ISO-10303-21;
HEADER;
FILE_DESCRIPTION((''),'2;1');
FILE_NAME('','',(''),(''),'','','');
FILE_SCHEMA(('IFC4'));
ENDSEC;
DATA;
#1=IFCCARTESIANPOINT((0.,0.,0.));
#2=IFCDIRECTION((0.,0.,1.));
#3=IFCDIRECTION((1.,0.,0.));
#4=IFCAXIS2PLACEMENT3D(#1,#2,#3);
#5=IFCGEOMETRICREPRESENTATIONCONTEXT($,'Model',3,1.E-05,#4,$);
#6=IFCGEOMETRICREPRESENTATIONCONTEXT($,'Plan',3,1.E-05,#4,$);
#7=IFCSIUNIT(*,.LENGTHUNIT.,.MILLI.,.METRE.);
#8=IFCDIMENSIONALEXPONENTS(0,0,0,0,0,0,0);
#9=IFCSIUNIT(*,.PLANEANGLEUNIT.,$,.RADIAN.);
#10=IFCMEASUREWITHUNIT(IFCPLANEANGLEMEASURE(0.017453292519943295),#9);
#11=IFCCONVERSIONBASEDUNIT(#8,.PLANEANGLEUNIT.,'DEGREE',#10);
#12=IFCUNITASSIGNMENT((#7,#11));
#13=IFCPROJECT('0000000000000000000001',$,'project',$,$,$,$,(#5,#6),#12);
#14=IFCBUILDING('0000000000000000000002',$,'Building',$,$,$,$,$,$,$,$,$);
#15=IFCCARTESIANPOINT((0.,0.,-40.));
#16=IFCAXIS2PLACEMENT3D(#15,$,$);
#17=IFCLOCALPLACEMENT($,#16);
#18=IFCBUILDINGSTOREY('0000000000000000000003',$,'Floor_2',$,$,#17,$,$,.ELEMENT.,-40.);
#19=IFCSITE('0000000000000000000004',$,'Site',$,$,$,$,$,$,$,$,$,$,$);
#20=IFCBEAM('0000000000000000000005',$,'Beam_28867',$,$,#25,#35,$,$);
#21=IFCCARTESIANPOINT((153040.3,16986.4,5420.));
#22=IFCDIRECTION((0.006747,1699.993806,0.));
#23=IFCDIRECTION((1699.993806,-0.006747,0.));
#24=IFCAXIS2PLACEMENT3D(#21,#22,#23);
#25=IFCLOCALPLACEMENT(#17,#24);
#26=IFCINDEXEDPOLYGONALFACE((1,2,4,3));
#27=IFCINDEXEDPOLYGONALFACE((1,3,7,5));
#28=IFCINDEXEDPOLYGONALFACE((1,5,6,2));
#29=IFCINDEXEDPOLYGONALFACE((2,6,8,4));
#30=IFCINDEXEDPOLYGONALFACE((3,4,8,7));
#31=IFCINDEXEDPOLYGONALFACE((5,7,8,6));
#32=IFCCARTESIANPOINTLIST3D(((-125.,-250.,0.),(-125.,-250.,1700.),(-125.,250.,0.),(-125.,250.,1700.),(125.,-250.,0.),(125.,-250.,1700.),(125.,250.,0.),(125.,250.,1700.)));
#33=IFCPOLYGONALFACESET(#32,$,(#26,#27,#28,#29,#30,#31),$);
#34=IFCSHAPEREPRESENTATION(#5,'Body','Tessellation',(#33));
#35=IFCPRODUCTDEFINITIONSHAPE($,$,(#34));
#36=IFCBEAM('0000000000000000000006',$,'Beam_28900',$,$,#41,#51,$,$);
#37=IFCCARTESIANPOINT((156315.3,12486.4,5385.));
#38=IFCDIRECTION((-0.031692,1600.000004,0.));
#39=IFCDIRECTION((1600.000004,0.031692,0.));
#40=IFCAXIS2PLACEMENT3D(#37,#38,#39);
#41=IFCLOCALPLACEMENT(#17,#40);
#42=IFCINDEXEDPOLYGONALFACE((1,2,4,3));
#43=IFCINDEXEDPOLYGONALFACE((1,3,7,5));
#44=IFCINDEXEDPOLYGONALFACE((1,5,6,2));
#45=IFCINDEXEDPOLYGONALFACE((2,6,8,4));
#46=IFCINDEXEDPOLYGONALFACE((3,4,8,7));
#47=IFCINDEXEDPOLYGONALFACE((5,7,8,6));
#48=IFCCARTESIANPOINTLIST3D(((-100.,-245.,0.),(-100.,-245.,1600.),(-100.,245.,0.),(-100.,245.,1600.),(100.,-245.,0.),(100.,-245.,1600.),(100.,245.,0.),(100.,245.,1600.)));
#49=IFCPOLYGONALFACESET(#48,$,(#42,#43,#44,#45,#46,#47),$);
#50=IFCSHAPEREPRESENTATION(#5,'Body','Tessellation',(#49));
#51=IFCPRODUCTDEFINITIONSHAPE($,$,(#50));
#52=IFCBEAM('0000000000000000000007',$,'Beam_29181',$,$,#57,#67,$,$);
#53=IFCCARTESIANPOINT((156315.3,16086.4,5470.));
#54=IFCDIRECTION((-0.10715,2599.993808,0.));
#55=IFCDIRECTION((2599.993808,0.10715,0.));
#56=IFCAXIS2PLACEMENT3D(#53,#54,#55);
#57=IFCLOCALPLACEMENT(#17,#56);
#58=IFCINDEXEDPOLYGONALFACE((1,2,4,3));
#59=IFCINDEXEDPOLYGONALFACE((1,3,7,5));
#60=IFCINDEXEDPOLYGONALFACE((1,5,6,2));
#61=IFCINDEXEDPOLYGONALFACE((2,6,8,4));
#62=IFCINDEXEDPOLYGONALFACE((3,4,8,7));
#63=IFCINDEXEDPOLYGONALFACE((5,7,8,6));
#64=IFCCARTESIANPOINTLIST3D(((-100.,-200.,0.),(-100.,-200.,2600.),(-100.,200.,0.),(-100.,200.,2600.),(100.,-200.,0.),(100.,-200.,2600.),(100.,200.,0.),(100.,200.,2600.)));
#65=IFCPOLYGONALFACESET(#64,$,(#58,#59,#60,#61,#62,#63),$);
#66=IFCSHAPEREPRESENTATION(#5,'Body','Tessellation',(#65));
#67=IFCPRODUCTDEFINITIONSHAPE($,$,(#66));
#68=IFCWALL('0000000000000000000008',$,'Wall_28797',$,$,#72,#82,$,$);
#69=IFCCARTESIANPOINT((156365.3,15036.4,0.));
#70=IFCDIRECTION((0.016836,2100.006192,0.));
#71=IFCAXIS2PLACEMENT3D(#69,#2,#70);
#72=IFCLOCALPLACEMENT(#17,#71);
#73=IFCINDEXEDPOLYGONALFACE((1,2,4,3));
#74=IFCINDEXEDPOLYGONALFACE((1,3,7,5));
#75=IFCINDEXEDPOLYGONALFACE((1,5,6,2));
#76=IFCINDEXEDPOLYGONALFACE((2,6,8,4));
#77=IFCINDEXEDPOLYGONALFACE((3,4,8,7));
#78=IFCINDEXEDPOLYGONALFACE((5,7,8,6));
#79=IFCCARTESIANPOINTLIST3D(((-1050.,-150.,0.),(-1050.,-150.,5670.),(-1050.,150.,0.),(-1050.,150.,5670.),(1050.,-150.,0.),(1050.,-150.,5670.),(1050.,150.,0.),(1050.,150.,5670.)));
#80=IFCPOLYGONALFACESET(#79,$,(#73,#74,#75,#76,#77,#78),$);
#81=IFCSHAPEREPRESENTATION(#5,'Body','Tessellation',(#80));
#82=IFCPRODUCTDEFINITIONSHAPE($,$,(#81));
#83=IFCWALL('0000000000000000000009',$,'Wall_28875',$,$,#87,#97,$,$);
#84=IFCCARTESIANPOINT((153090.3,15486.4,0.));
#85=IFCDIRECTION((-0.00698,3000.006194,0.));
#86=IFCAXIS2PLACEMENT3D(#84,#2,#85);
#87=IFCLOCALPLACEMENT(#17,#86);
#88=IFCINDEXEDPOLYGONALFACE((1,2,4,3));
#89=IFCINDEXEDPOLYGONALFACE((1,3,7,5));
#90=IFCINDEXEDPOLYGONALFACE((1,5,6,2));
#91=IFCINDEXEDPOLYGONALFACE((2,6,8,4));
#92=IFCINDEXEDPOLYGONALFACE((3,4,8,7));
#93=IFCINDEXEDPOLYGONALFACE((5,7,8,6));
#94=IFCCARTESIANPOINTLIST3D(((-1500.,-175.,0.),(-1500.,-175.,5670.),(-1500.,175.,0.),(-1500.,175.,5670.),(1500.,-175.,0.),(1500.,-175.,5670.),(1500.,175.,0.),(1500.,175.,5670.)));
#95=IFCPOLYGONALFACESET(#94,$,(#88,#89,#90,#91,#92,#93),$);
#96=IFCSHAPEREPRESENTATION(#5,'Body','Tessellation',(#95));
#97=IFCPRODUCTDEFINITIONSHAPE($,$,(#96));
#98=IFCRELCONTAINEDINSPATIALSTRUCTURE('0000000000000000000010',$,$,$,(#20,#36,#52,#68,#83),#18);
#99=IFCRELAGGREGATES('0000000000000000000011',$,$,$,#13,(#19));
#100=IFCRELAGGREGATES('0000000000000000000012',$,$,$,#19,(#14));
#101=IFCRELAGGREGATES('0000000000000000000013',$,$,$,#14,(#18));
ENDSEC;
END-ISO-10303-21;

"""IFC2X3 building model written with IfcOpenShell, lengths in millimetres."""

from ifc_helpers import new_model, entity, si_unit, converted_unit, frame, origin_with_axes, origin_2d, place, context, project, spatial, rectangle, extrude, element, save


model = new_model("IFC2X3")

# Units and contexts
model_context = context("Model", 3, precision=1e-05, world=origin_with_axes())
plan_context = context("Plan", 3, precision=1e-05, world=origin_with_axes())
ifc_project = project(units=[si_unit("LENGTHUNIT", "METRE", prefix="MILLI"), converted_unit("PLANEANGLEUNIT", "DEGREE", entity("IfcPlaneAngleMeasure", 0.017453292519943295), si_unit("PLANEANGLEUNIT", "RADIAN"), dimensions=[0, 0, 0, 0, 0, 0, 0])], contexts=[model_context, plan_context])

# Site, building, storey
site = spatial("IfcSite", under=ifc_project, Name="Site")
building = spatial("IfcBuilding", under=site, Name="Building")
storey_placement = place(None, frame((0.0, 0.0, -40.0)))
storey = spatial("IfcBuildingStorey", under=building, at=storey_placement, Name="Floor_2", CompositionType="ELEMENT", Elevation=-40.0)

# Beams
beam_1_placement = place(storey_placement, frame((153040.3, 16986.4, 5420.0), z_axis=(0.006747, 1699.993806, 0.0), x_axis=(1699.993806, -0.006747, 0.0)))
element("IfcBeam", 1, at=beam_1_placement, inside=storey, Name="Beam_28867", context=model_context, shape_type="SweptSolid", body=[
    extrude(rectangle(XDim=250.0, YDim=500.0, at=origin_2d()), origin_with_axes(), (0.0, 0.0, 1.0), 1700.0),
])
beam_2_placement = place(storey_placement, frame((156315.3, 12486.4, 5385.0), z_axis=(-0.031692, 1600.000004, 0.0), x_axis=(1600.000004, 0.031692, 0.0)))
element("IfcBeam", 2, at=beam_2_placement, inside=storey, Name="Beam_28900", context=model_context, shape_type="SweptSolid", body=[
    extrude(rectangle(XDim=200.0, YDim=490.0, at=origin_2d()), origin_with_axes(), (0.0, 0.0, 1.0), 1600.0),
])
beam_3_placement = place(storey_placement, frame((156315.3, 16086.4, 5470.0), z_axis=(-0.10715, 2599.993808, 0.0), x_axis=(2599.993808, 0.10715, 0.0)))
element("IfcBeam", 3, at=beam_3_placement, inside=storey, Name="Beam_29181", context=model_context, shape_type="SweptSolid", body=[
    extrude(rectangle(XDim=200.0, YDim=400.0, at=origin_2d()), origin_with_axes(), (0.0, 0.0, 1.0), 2600.0),
])

# Walls
wall_1_placement = place(storey_placement, frame((156365.3, 15036.4, 0.0), z_axis=(0.0, 0.0, 1.0), x_axis=(0.016836, 2100.006192, 0.0)))
element("IfcWall", 4, at=wall_1_placement, inside=storey, Name="Wall_28797", context=model_context, shape_type="SweptSolid", body=[
    extrude(rectangle(XDim=2100.0, YDim=300.0, at=origin_2d()), origin_with_axes(), (0.0, 0.0, 1.0), 5670.0),
])
wall_2_placement = place(storey_placement, frame((153090.3, 15486.4, 0.0), z_axis=(0.0, 0.0, 1.0), x_axis=(-0.00698, 3000.006194, 0.0)))
element("IfcWall", 5, at=wall_2_placement, inside=storey, Name="Wall_28875", context=model_context, shape_type="SweptSolid", body=[
    extrude(rectangle(XDim=3000.0, YDim=350.0, at=origin_2d()), origin_with_axes(), (0.0, 0.0, 1.0), 5670.0),
])

save(model, "model.ifc")
